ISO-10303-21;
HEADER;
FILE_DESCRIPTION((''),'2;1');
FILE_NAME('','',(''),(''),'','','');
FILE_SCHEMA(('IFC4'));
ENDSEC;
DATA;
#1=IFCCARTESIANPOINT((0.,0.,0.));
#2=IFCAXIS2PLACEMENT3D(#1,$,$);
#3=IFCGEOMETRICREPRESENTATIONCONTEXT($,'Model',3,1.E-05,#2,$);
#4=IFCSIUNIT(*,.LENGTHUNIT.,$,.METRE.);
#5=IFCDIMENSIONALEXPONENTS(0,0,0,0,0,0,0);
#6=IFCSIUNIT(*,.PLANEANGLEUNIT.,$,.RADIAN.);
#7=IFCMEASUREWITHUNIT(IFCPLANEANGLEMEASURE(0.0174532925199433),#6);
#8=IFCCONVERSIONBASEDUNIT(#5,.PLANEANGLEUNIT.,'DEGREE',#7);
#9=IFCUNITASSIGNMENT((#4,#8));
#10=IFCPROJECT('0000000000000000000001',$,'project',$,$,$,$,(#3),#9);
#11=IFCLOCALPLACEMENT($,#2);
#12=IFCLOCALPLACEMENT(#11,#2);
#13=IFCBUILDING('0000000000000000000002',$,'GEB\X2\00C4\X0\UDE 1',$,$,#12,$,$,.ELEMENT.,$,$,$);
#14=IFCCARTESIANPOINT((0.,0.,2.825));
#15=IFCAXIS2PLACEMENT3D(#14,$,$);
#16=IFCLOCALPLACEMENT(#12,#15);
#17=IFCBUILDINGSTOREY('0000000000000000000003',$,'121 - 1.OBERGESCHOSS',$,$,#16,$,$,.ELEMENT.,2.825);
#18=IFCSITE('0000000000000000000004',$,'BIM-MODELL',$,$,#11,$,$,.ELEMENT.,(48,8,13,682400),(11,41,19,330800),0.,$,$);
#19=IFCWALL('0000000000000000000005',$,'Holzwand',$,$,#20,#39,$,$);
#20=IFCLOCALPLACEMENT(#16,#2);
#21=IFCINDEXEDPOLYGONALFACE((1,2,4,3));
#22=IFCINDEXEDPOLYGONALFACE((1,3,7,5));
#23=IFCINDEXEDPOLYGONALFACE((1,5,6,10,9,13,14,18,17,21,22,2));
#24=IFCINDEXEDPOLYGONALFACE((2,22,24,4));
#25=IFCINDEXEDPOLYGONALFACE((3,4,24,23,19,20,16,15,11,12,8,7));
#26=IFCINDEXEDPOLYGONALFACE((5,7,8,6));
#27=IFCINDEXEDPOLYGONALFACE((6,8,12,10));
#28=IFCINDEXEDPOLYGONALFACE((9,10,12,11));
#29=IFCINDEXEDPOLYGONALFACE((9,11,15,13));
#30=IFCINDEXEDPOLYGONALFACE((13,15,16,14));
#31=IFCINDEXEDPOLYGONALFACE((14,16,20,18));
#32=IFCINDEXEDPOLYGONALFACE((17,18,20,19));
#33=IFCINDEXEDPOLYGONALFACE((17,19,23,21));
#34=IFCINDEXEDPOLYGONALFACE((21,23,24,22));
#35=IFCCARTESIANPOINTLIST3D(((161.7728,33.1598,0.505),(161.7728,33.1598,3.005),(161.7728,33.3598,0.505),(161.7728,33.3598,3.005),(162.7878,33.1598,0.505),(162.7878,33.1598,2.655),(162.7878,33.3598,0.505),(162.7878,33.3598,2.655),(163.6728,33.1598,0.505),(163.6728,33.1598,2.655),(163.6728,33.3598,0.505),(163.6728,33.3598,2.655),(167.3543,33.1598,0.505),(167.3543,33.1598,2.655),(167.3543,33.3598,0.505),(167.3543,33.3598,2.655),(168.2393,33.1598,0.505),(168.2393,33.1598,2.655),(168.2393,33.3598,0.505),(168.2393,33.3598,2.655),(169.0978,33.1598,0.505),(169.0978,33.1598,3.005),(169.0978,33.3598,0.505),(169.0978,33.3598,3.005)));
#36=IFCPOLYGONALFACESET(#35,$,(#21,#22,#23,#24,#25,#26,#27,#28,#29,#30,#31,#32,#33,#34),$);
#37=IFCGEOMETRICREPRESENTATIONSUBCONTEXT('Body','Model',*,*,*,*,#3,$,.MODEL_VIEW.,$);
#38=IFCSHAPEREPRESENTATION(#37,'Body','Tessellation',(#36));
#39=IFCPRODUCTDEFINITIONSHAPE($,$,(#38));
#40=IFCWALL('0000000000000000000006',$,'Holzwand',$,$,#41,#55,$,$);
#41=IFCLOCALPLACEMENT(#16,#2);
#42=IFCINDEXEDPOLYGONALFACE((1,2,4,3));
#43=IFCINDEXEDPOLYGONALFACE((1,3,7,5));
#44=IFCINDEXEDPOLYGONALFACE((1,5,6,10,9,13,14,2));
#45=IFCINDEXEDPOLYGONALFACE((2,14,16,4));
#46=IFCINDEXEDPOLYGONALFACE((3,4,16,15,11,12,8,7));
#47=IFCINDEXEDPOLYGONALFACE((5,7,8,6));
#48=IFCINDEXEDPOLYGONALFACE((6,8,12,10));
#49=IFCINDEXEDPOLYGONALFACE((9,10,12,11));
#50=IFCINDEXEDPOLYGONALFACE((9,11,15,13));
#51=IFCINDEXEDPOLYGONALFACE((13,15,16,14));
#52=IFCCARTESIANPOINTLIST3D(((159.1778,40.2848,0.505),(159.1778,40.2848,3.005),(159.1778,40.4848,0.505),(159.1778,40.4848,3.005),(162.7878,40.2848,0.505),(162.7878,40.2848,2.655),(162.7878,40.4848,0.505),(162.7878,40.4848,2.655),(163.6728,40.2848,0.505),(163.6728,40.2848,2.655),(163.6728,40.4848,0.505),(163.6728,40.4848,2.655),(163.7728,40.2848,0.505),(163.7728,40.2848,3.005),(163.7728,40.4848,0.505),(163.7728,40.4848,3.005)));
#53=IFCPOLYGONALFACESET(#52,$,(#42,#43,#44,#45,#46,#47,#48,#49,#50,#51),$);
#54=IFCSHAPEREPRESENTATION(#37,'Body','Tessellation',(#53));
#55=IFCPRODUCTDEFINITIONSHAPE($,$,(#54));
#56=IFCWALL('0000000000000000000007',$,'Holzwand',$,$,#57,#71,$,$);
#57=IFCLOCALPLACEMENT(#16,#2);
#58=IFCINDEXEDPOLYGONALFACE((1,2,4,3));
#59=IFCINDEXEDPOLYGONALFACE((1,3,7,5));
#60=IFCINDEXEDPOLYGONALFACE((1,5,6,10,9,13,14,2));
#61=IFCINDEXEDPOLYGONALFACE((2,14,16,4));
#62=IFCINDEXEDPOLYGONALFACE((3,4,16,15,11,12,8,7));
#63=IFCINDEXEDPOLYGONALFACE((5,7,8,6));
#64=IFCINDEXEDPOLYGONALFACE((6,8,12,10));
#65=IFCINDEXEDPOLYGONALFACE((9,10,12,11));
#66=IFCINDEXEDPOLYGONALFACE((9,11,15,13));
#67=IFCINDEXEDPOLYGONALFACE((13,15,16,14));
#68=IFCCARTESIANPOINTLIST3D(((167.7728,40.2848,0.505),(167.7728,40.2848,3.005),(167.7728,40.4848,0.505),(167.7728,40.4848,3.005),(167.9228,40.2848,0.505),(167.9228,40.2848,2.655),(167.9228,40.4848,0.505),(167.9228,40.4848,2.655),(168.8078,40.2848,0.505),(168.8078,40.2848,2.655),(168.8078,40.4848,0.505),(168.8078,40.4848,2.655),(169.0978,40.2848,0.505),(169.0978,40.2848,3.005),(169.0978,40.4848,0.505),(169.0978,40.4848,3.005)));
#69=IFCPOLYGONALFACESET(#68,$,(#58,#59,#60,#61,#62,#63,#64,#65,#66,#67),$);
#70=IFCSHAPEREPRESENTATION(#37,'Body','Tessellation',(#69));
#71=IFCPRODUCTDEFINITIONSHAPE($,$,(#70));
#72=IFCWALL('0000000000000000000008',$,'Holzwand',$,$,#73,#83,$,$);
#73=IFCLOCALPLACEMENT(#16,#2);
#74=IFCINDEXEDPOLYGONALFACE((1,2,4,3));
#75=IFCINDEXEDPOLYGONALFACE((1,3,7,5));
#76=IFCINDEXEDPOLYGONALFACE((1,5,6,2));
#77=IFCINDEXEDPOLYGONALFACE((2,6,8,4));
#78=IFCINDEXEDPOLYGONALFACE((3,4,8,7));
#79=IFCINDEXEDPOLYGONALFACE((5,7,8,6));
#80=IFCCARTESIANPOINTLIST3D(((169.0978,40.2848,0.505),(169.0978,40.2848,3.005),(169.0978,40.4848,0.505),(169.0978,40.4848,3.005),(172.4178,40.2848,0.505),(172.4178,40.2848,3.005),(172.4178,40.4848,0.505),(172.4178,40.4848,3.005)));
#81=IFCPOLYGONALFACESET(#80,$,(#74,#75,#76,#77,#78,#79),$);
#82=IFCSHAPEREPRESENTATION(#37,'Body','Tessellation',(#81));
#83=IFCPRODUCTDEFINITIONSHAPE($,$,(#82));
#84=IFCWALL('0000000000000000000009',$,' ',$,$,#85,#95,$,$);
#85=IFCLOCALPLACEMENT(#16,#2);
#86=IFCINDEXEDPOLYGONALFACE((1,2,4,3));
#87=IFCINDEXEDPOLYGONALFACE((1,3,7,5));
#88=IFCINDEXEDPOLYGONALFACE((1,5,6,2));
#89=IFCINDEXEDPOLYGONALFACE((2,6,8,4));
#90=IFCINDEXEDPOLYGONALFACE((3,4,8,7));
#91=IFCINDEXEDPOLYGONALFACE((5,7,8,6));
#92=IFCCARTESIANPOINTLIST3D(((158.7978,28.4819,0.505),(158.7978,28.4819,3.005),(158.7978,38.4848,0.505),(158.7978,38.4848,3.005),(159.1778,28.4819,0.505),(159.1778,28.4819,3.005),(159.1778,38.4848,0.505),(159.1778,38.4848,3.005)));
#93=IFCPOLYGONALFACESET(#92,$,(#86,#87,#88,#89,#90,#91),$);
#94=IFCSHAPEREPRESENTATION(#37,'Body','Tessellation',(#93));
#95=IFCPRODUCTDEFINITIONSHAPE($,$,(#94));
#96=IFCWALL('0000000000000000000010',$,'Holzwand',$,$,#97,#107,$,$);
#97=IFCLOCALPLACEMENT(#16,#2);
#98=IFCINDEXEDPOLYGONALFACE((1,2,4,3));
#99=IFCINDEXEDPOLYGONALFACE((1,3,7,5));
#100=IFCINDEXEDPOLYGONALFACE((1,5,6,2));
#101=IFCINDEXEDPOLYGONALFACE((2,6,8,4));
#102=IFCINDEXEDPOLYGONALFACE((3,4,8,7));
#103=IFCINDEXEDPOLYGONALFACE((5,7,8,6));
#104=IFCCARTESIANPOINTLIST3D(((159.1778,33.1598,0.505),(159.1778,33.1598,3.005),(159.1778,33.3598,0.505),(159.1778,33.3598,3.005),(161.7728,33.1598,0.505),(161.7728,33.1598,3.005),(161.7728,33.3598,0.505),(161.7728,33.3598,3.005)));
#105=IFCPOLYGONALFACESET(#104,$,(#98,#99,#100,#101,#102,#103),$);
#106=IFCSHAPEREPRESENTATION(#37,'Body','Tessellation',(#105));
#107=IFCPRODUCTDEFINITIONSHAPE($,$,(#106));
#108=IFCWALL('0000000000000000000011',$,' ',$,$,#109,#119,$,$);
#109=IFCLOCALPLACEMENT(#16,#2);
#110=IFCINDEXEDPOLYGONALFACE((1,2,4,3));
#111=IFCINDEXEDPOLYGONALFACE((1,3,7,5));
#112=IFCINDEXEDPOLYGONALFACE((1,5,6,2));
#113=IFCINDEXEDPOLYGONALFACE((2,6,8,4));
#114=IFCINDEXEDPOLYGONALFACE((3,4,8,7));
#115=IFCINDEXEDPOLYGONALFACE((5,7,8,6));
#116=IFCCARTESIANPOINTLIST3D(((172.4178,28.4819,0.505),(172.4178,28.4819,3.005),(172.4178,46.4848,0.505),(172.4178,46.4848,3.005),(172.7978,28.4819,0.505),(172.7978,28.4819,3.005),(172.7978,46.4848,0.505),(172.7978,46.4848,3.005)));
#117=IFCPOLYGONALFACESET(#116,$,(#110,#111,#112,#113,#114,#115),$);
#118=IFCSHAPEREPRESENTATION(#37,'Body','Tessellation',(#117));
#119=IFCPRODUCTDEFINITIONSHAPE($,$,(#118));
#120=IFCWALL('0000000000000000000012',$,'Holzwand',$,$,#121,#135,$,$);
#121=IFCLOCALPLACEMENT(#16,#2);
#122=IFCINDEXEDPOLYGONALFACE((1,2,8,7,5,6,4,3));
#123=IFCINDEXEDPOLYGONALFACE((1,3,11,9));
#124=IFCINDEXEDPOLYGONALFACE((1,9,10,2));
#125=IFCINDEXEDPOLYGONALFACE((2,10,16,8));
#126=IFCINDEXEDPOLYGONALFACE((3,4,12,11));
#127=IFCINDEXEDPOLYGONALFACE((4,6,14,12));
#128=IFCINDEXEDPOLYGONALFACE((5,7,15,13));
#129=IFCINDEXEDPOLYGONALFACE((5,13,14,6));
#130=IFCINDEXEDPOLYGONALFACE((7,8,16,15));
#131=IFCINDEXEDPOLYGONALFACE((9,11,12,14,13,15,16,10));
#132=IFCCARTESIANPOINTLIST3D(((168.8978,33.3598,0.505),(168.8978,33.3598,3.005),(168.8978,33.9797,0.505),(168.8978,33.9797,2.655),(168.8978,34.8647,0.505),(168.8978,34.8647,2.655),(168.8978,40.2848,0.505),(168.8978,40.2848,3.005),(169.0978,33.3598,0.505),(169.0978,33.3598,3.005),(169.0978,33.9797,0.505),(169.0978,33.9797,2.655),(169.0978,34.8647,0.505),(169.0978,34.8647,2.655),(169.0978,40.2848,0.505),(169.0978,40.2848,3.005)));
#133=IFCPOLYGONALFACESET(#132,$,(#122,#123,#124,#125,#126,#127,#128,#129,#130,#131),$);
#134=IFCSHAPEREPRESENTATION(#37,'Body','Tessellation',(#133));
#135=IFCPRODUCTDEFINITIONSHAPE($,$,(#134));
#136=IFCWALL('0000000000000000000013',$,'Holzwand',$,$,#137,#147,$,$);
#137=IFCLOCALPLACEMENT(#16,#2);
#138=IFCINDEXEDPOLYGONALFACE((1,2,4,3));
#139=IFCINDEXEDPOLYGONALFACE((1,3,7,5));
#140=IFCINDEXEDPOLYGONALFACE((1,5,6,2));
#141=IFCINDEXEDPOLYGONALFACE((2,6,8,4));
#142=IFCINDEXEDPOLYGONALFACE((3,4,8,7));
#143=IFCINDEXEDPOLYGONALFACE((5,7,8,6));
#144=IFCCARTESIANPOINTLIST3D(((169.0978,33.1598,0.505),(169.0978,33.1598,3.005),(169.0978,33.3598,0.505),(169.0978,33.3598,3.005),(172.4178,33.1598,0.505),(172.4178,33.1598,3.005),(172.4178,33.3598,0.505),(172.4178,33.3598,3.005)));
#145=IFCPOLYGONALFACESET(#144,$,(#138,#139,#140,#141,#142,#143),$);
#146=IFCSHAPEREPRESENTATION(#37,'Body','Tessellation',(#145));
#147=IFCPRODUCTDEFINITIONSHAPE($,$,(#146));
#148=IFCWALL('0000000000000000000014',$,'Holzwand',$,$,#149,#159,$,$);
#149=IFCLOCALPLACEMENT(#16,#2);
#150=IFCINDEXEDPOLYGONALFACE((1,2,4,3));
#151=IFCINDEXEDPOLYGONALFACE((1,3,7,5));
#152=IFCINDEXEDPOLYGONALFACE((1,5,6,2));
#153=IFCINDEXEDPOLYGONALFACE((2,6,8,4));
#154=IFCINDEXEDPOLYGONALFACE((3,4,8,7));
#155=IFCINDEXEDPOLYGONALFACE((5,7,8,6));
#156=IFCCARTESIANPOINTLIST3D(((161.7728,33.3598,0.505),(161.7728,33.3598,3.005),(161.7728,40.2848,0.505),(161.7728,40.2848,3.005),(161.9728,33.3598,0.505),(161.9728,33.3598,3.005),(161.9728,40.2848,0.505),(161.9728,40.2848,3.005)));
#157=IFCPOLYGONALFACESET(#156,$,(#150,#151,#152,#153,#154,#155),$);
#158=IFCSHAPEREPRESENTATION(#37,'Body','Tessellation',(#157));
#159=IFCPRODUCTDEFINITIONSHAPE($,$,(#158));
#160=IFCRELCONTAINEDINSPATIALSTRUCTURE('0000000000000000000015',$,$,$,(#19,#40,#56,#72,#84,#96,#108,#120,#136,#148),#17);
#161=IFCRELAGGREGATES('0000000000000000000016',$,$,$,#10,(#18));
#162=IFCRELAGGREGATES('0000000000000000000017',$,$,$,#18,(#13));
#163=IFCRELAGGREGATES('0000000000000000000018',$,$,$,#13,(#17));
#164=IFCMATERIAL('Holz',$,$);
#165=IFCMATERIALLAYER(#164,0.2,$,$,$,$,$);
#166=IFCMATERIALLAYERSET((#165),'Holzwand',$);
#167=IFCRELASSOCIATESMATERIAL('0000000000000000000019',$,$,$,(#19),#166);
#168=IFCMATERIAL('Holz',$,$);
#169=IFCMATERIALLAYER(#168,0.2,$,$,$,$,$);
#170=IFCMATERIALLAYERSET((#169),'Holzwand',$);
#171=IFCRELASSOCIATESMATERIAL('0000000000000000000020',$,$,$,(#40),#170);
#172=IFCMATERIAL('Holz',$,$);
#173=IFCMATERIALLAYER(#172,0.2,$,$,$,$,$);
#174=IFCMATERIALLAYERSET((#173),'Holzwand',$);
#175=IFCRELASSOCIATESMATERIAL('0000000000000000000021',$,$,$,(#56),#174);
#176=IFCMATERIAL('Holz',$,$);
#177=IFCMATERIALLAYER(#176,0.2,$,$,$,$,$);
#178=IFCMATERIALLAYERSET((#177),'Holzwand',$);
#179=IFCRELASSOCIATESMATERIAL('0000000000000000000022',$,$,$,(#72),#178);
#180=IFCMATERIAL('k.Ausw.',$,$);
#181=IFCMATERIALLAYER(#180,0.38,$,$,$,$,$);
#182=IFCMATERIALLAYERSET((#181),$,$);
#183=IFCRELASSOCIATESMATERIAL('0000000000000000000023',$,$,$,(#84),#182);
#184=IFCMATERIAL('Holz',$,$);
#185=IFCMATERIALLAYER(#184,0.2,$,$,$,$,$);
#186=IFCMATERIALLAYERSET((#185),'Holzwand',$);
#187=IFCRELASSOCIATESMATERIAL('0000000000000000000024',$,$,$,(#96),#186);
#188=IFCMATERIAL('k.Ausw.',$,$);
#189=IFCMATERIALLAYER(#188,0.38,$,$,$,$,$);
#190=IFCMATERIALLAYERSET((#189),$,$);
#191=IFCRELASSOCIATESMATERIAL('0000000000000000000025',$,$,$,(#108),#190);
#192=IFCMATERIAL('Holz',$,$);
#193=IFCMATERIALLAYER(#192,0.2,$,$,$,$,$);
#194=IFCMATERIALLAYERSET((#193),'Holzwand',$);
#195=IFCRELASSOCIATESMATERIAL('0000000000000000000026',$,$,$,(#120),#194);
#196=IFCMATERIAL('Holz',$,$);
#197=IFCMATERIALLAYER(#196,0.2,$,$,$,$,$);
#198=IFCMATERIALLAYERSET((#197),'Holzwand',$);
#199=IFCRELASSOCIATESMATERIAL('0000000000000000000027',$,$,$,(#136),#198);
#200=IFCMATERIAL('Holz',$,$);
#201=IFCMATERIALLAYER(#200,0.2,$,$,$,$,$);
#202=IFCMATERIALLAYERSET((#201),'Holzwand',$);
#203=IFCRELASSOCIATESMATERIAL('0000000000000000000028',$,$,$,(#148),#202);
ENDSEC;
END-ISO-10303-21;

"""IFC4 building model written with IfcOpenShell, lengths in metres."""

from ifc_helpers import new_model, entity, si_unit, converted_unit, frame, frame_2d, origin, origin_with_axes, place, context, subcontext, project, spatial, polyline, rectangle, outline, extrude, material, layer, layer_set, layer_usage, element, save


model = new_model("IFC4")

# Units and contexts
model_context = context("Model", 3, precision=1e-05, world=origin())
body_context = subcontext(model_context, "Body", "Model", "MODEL_VIEW")
ifc_project = project(units=[si_unit("LENGTHUNIT", "METRE"), converted_unit("PLANEANGLEUNIT", "DEGREE", entity("IfcPlaneAngleMeasure", 0.0174532925199433), si_unit("PLANEANGLEUNIT", "RADIAN"), dimensions=[0, 0, 0, 0, 0, 0, 0])], contexts=[model_context])

# Site, building, storey
site_placement = place(None, origin())
site = spatial("IfcSite", under=ifc_project, at=site_placement, Name="BIM-MODELL", CompositionType="ELEMENT", RefLatitude=(48, 8, 13, 682400), RefLongitude=(11, 41, 19, 330800), RefElevation=0.0)
building_placement = place(site_placement, origin())
building = spatial("IfcBuilding", under=site, at=building_placement, Name="GEBÄUDE 1", CompositionType="ELEMENT")
storey_placement = place(building_placement, frame((0.0, 0.0, 2.825)))
storey = spatial("IfcBuildingStorey", under=building, at=storey_placement, Name="121 - 1.OBERGESCHOSS", CompositionType="ELEMENT", Elevation=2.825)

# Wall, openings
ifc_material_1 = material(Name="Holz")
ifc_layer_1 = layer(ifc_material_1, 0.2)
ifc_layer_set_1 = layer_set([ifc_layer_1], Name="Holzwand")
ifc_layer_usage_1 = layer_usage(ifc_layer_set_1, "AXIS2", "POSITIVE", 0.0)
wall_1_placement = place(storey_placement, frame((169.0978, 33.3598, 0.505), z_axis=(0.0, 0.0, 1.0), x_axis=(-1.0, 0.0, 0.0)))
wall_1 = element("IfcWall", 1, at=wall_1_placement, inside=storey, material=ifc_layer_usage_1, Name="Holzwand", context=body_context, shape_type="SweptSolid", body=[
    extrude(rectangle(XDim=7.325, YDim=0.2, at=frame_2d((3.6625, 0.1), x_axis=(1.0, 0.0))), origin_with_axes(), (0.0, 0.0, 1.0), 2.5),
])
opening_1_placement = place(wall_1_placement, frame((0.8585, 0.0, -0.15), z_axis=(0.0, 1.0, 0.0), x_axis=(0.0, 0.0, 1.0)))
element("IfcOpeningElement", 2, at=opening_1_placement, cuts=wall_1, ObjectType="Opening", context=body_context, shape_type="SweptSolid", body=[
    extrude(outline(polyline([(0.0, 0.885), (2.3, 0.885), (2.3, 0.0), (0.0, 0.0), (0.0, 0.885)])), origin_with_axes(), (0.0, 0.0, 1.0), 0.2),
])
opening_2_placement = place(wall_1_placement, frame((5.425, 0.0, -0.15), z_axis=(0.0, 1.0, 0.0), x_axis=(0.0, 0.0, 1.0)))
element("IfcOpeningElement", 3, at=opening_2_placement, cuts=wall_1, ObjectType="Opening", context=body_context, shape_type="SweptSolid", body=[
    extrude(outline(polyline([(0.0, 0.885), (2.3, 0.885), (2.3, 0.0), (0.0, 0.0), (0.0, 0.885)])), origin_with_axes(), (0.0, 0.0, 1.0), 0.2),
])

# Walls, openings
ifc_material_2 = material(Name="Holz")
ifc_layer_2 = layer(ifc_material_2, 0.2)
ifc_layer_set_2 = layer_set([ifc_layer_2], Name="Holzwand")
ifc_layer_usage_2 = layer_usage(ifc_layer_set_2, "AXIS2", "POSITIVE", 0.0)
wall_2_placement = place(storey_placement, frame((163.7728, 40.4848, 0.505), z_axis=(0.0, 0.0, 1.0), x_axis=(-1.0, 0.0, 0.0)))
wall_2 = element("IfcWall", 4, at=wall_2_placement, inside=storey, material=ifc_layer_usage_2, Name="Holzwand", context=body_context, shape_type="SweptSolid", body=[
    extrude(rectangle(XDim=4.595, YDim=0.2, at=frame_2d((2.2975, 0.1), x_axis=(1.0, 0.0))), origin_with_axes(), (0.0, 0.0, 1.0), 2.5),
])
opening_3_placement = place(wall_2_placement, frame((0.985, 0.2, -0.15), z_axis=(0.0, -1.0, 0.0), x_axis=(0.0, 0.0, 1.0)))
element("IfcOpeningElement", 5, at=opening_3_placement, cuts=wall_2, ObjectType="Opening", context=body_context, shape_type="SweptSolid", body=[
    extrude(outline(polyline([(0.0, 0.885), (2.3, 0.885), (2.3, 0.0), (0.0, 0.0), (0.0, 0.885)])), origin_with_axes(), (0.0, 0.0, 1.0), 0.2),
])
ifc_material_3 = material(Name="Holz")
ifc_layer_3 = layer(ifc_material_3, 0.2)
ifc_layer_set_3 = layer_set([ifc_layer_3], Name="Holzwand")
ifc_layer_usage_3 = layer_usage(ifc_layer_set_3, "AXIS2", "POSITIVE", 0.0)
wall_3_placement = place(storey_placement, frame((169.0978, 40.4848, 0.505), z_axis=(0.0, 0.0, 1.0), x_axis=(-1.0, 0.0, 0.0)))
wall_3 = element("IfcWall", 6, at=wall_3_placement, inside=storey, material=ifc_layer_usage_3, Name="Holzwand", context=body_context, shape_type="SweptSolid", body=[
    extrude(rectangle(XDim=1.325, YDim=0.2, at=frame_2d((0.6625, 0.1), x_axis=(1.0, 0.0))), origin_with_axes(), (0.0, 0.0, 1.0), 2.5),
])
opening_4_placement = place(wall_3_placement, frame((1.175, 0.2, -0.15), z_axis=(0.0, -1.0, 0.0), x_axis=(0.0, 0.0, 1.0)))
element("IfcOpeningElement", 7, at=opening_4_placement, cuts=wall_3, ObjectType="Opening", context=body_context, shape_type="SweptSolid", body=[
    extrude(outline(polyline([(0.0, 0.885), (2.3, 0.885), (2.3, 0.0), (0.0, 0.0), (0.0, 0.885)])), origin_with_axes(), (0.0, 0.0, 1.0), 0.2),
])

# Walls
ifc_material_4 = material(Name="Holz")
ifc_layer_4 = layer(ifc_material_4, 0.2)
ifc_layer_set_4 = layer_set([ifc_layer_4], Name="Holzwand")
ifc_layer_usage_4 = layer_usage(ifc_layer_set_4, "AXIS2", "POSITIVE", -0.1)
wall_4_placement = place(storey_placement, frame((172.4178, 40.4848, 0.505), z_axis=(0.0, 0.0, 1.0), x_axis=(-1.0, 0.0, 0.0)))
element("IfcWall", 8, at=wall_4_placement, inside=storey, material=ifc_layer_usage_4, Name="Holzwand", context=body_context, shape_type="SweptSolid", body=[
    extrude(rectangle(XDim=3.32, YDim=0.2, at=frame_2d((1.66, 0.1), x_axis=(1.0, 0.0))), origin_with_axes(), (0.0, 0.0, 1.0), 2.5),
])
ifc_material_5 = material(Name="k.Ausw.")
ifc_layer_5 = layer(ifc_material_5, 0.38)
ifc_layer_set_5 = layer_set([ifc_layer_5])
ifc_layer_usage_5 = layer_usage(ifc_layer_set_5, "AXIS2", "POSITIVE", 0.0)
wall_5_placement = place(storey_placement, frame((158.7978, 38.4848, 0.505), z_axis=(0.0, 0.0, 1.0), x_axis=(0.0, -1.0, 0.0)))
element("IfcWall", 9, at=wall_5_placement, inside=storey, material=ifc_layer_usage_5, Name=" ", context=body_context, shape_type="SweptSolid", body=[
    extrude(rectangle(XDim=10.0029, YDim=0.38, at=frame_2d((5.0014, 0.19), x_axis=(1.0, 0.0))), origin_with_axes(), (0.0, 0.0, 1.0), 2.5),
])
ifc_material_6 = material(Name="Holz")
ifc_layer_6 = layer(ifc_material_6, 0.2)
ifc_layer_set_6 = layer_set([ifc_layer_6], Name="Holzwand")
ifc_layer_usage_6 = layer_usage(ifc_layer_set_6, "AXIS2", "POSITIVE", 0.0)
wall_6_placement = place(storey_placement, frame((159.1778, 33.1598, 0.505)))
element("IfcWall", 10, at=wall_6_placement, inside=storey, material=ifc_layer_usage_6, Name="Holzwand", context=body_context, shape_type="SweptSolid", body=[
    extrude(rectangle(XDim=2.595, YDim=0.2, at=frame_2d((1.2975, 0.1), x_axis=(1.0, 0.0))), origin_with_axes(), (0.0, 0.0, 1.0), 2.5),
])
ifc_material_7 = material(Name="k.Ausw.")
ifc_layer_7 = layer(ifc_material_7, 0.38)
ifc_layer_set_7 = layer_set([ifc_layer_7])
ifc_layer_usage_7 = layer_usage(ifc_layer_set_7, "AXIS2", "POSITIVE", 0.0)
wall_7_placement = place(storey_placement, frame((172.7978, 28.4819, 0.505), z_axis=(0.0, 0.0, 1.0), x_axis=(0.0, 1.0, 0.0)))
element("IfcWall", 11, at=wall_7_placement, inside=storey, material=ifc_layer_usage_7, Name=" ", context=body_context, shape_type="SweptSolid", body=[
    extrude(rectangle(XDim=18.0029, YDim=0.38, at=frame_2d((9.0014, 0.19), x_axis=(1.0, 0.0))), origin_with_axes(), (0.0, 0.0, 1.0), 2.5),
])

# Wall, opening
ifc_material_8 = material(Name="Holz")
ifc_layer_8 = layer(ifc_material_8, 0.2)
ifc_layer_set_8 = layer_set([ifc_layer_8], Name="Holzwand")
ifc_layer_usage_8 = layer_usage(ifc_layer_set_8, "AXIS2", "POSITIVE", 0.0)
wall_8_placement = place(storey_placement, frame((168.8978, 40.2848, 0.505), z_axis=(0.0, 0.0, 1.0), x_axis=(0.0, -1.0, 0.0)))
wall_8 = element("IfcWall", 12, at=wall_8_placement, inside=storey, material=ifc_layer_usage_8, Name="Holzwand", context=body_context, shape_type="SweptSolid", body=[
    extrude(rectangle(XDim=6.925, YDim=0.2, at=frame_2d((3.4625, 0.1), x_axis=(1.0, 0.0))), origin_with_axes(), (0.0, 0.0, 1.0), 2.5),
])
opening_5_placement = place(wall_8_placement, frame((5.4201, 0.0, -0.15), z_axis=(0.0, 1.0, 0.0), x_axis=(0.0, 0.0, 1.0)))
element("IfcOpeningElement", 13, at=opening_5_placement, cuts=wall_8, ObjectType="Opening", context=body_context, shape_type="SweptSolid", body=[
    extrude(outline(polyline([(0.0, 0.885), (2.3, 0.885), (2.3, 0.0), (0.0, 0.0), (0.0, 0.885)])), origin_with_axes(), (0.0, 0.0, 1.0), 0.2),
])

# Walls
ifc_material_9 = material(Name="Holz")
ifc_layer_9 = layer(ifc_material_9, 0.2)
ifc_layer_set_9 = layer_set([ifc_layer_9], Name="Holzwand")
ifc_layer_usage_9 = layer_usage(ifc_layer_set_9, "AXIS2", "POSITIVE", 0.0)
wall_9_placement = place(storey_placement, frame((169.0978, 33.1598, 0.505)))
element("IfcWall", 14, at=wall_9_placement, inside=storey, material=ifc_layer_usage_9, Name="Holzwand", context=body_context, shape_type="SweptSolid", body=[
    extrude(rectangle(XDim=3.32, YDim=0.2, at=frame_2d((1.66, 0.1), x_axis=(1.0, 0.0))), origin_with_axes(), (0.0, 0.0, 1.0), 2.5),
])
ifc_material_10 = material(Name="Holz")
ifc_layer_10 = layer(ifc_material_10, 0.2)
ifc_layer_set_10 = layer_set([ifc_layer_10], Name="Holzwand")
ifc_layer_usage_10 = layer_usage(ifc_layer_set_10, "AXIS2", "POSITIVE", 0.0)
wall_10_placement = place(storey_placement, frame((161.9728, 33.3598, 0.505), z_axis=(0.0, 0.0, 1.0), x_axis=(0.0, 1.0, 0.0)))
element("IfcWall", 15, at=wall_10_placement, inside=storey, material=ifc_layer_usage_10, Name="Holzwand", context=body_context, shape_type="SweptSolid", body=[
    extrude(rectangle(XDim=6.925, YDim=0.2, at=frame_2d((3.4625, 0.1), x_axis=(1.0, 0.0))), origin_with_axes(), (0.0, 0.0, 1.0), 2.5),
])

save(model, "model.ifc")
